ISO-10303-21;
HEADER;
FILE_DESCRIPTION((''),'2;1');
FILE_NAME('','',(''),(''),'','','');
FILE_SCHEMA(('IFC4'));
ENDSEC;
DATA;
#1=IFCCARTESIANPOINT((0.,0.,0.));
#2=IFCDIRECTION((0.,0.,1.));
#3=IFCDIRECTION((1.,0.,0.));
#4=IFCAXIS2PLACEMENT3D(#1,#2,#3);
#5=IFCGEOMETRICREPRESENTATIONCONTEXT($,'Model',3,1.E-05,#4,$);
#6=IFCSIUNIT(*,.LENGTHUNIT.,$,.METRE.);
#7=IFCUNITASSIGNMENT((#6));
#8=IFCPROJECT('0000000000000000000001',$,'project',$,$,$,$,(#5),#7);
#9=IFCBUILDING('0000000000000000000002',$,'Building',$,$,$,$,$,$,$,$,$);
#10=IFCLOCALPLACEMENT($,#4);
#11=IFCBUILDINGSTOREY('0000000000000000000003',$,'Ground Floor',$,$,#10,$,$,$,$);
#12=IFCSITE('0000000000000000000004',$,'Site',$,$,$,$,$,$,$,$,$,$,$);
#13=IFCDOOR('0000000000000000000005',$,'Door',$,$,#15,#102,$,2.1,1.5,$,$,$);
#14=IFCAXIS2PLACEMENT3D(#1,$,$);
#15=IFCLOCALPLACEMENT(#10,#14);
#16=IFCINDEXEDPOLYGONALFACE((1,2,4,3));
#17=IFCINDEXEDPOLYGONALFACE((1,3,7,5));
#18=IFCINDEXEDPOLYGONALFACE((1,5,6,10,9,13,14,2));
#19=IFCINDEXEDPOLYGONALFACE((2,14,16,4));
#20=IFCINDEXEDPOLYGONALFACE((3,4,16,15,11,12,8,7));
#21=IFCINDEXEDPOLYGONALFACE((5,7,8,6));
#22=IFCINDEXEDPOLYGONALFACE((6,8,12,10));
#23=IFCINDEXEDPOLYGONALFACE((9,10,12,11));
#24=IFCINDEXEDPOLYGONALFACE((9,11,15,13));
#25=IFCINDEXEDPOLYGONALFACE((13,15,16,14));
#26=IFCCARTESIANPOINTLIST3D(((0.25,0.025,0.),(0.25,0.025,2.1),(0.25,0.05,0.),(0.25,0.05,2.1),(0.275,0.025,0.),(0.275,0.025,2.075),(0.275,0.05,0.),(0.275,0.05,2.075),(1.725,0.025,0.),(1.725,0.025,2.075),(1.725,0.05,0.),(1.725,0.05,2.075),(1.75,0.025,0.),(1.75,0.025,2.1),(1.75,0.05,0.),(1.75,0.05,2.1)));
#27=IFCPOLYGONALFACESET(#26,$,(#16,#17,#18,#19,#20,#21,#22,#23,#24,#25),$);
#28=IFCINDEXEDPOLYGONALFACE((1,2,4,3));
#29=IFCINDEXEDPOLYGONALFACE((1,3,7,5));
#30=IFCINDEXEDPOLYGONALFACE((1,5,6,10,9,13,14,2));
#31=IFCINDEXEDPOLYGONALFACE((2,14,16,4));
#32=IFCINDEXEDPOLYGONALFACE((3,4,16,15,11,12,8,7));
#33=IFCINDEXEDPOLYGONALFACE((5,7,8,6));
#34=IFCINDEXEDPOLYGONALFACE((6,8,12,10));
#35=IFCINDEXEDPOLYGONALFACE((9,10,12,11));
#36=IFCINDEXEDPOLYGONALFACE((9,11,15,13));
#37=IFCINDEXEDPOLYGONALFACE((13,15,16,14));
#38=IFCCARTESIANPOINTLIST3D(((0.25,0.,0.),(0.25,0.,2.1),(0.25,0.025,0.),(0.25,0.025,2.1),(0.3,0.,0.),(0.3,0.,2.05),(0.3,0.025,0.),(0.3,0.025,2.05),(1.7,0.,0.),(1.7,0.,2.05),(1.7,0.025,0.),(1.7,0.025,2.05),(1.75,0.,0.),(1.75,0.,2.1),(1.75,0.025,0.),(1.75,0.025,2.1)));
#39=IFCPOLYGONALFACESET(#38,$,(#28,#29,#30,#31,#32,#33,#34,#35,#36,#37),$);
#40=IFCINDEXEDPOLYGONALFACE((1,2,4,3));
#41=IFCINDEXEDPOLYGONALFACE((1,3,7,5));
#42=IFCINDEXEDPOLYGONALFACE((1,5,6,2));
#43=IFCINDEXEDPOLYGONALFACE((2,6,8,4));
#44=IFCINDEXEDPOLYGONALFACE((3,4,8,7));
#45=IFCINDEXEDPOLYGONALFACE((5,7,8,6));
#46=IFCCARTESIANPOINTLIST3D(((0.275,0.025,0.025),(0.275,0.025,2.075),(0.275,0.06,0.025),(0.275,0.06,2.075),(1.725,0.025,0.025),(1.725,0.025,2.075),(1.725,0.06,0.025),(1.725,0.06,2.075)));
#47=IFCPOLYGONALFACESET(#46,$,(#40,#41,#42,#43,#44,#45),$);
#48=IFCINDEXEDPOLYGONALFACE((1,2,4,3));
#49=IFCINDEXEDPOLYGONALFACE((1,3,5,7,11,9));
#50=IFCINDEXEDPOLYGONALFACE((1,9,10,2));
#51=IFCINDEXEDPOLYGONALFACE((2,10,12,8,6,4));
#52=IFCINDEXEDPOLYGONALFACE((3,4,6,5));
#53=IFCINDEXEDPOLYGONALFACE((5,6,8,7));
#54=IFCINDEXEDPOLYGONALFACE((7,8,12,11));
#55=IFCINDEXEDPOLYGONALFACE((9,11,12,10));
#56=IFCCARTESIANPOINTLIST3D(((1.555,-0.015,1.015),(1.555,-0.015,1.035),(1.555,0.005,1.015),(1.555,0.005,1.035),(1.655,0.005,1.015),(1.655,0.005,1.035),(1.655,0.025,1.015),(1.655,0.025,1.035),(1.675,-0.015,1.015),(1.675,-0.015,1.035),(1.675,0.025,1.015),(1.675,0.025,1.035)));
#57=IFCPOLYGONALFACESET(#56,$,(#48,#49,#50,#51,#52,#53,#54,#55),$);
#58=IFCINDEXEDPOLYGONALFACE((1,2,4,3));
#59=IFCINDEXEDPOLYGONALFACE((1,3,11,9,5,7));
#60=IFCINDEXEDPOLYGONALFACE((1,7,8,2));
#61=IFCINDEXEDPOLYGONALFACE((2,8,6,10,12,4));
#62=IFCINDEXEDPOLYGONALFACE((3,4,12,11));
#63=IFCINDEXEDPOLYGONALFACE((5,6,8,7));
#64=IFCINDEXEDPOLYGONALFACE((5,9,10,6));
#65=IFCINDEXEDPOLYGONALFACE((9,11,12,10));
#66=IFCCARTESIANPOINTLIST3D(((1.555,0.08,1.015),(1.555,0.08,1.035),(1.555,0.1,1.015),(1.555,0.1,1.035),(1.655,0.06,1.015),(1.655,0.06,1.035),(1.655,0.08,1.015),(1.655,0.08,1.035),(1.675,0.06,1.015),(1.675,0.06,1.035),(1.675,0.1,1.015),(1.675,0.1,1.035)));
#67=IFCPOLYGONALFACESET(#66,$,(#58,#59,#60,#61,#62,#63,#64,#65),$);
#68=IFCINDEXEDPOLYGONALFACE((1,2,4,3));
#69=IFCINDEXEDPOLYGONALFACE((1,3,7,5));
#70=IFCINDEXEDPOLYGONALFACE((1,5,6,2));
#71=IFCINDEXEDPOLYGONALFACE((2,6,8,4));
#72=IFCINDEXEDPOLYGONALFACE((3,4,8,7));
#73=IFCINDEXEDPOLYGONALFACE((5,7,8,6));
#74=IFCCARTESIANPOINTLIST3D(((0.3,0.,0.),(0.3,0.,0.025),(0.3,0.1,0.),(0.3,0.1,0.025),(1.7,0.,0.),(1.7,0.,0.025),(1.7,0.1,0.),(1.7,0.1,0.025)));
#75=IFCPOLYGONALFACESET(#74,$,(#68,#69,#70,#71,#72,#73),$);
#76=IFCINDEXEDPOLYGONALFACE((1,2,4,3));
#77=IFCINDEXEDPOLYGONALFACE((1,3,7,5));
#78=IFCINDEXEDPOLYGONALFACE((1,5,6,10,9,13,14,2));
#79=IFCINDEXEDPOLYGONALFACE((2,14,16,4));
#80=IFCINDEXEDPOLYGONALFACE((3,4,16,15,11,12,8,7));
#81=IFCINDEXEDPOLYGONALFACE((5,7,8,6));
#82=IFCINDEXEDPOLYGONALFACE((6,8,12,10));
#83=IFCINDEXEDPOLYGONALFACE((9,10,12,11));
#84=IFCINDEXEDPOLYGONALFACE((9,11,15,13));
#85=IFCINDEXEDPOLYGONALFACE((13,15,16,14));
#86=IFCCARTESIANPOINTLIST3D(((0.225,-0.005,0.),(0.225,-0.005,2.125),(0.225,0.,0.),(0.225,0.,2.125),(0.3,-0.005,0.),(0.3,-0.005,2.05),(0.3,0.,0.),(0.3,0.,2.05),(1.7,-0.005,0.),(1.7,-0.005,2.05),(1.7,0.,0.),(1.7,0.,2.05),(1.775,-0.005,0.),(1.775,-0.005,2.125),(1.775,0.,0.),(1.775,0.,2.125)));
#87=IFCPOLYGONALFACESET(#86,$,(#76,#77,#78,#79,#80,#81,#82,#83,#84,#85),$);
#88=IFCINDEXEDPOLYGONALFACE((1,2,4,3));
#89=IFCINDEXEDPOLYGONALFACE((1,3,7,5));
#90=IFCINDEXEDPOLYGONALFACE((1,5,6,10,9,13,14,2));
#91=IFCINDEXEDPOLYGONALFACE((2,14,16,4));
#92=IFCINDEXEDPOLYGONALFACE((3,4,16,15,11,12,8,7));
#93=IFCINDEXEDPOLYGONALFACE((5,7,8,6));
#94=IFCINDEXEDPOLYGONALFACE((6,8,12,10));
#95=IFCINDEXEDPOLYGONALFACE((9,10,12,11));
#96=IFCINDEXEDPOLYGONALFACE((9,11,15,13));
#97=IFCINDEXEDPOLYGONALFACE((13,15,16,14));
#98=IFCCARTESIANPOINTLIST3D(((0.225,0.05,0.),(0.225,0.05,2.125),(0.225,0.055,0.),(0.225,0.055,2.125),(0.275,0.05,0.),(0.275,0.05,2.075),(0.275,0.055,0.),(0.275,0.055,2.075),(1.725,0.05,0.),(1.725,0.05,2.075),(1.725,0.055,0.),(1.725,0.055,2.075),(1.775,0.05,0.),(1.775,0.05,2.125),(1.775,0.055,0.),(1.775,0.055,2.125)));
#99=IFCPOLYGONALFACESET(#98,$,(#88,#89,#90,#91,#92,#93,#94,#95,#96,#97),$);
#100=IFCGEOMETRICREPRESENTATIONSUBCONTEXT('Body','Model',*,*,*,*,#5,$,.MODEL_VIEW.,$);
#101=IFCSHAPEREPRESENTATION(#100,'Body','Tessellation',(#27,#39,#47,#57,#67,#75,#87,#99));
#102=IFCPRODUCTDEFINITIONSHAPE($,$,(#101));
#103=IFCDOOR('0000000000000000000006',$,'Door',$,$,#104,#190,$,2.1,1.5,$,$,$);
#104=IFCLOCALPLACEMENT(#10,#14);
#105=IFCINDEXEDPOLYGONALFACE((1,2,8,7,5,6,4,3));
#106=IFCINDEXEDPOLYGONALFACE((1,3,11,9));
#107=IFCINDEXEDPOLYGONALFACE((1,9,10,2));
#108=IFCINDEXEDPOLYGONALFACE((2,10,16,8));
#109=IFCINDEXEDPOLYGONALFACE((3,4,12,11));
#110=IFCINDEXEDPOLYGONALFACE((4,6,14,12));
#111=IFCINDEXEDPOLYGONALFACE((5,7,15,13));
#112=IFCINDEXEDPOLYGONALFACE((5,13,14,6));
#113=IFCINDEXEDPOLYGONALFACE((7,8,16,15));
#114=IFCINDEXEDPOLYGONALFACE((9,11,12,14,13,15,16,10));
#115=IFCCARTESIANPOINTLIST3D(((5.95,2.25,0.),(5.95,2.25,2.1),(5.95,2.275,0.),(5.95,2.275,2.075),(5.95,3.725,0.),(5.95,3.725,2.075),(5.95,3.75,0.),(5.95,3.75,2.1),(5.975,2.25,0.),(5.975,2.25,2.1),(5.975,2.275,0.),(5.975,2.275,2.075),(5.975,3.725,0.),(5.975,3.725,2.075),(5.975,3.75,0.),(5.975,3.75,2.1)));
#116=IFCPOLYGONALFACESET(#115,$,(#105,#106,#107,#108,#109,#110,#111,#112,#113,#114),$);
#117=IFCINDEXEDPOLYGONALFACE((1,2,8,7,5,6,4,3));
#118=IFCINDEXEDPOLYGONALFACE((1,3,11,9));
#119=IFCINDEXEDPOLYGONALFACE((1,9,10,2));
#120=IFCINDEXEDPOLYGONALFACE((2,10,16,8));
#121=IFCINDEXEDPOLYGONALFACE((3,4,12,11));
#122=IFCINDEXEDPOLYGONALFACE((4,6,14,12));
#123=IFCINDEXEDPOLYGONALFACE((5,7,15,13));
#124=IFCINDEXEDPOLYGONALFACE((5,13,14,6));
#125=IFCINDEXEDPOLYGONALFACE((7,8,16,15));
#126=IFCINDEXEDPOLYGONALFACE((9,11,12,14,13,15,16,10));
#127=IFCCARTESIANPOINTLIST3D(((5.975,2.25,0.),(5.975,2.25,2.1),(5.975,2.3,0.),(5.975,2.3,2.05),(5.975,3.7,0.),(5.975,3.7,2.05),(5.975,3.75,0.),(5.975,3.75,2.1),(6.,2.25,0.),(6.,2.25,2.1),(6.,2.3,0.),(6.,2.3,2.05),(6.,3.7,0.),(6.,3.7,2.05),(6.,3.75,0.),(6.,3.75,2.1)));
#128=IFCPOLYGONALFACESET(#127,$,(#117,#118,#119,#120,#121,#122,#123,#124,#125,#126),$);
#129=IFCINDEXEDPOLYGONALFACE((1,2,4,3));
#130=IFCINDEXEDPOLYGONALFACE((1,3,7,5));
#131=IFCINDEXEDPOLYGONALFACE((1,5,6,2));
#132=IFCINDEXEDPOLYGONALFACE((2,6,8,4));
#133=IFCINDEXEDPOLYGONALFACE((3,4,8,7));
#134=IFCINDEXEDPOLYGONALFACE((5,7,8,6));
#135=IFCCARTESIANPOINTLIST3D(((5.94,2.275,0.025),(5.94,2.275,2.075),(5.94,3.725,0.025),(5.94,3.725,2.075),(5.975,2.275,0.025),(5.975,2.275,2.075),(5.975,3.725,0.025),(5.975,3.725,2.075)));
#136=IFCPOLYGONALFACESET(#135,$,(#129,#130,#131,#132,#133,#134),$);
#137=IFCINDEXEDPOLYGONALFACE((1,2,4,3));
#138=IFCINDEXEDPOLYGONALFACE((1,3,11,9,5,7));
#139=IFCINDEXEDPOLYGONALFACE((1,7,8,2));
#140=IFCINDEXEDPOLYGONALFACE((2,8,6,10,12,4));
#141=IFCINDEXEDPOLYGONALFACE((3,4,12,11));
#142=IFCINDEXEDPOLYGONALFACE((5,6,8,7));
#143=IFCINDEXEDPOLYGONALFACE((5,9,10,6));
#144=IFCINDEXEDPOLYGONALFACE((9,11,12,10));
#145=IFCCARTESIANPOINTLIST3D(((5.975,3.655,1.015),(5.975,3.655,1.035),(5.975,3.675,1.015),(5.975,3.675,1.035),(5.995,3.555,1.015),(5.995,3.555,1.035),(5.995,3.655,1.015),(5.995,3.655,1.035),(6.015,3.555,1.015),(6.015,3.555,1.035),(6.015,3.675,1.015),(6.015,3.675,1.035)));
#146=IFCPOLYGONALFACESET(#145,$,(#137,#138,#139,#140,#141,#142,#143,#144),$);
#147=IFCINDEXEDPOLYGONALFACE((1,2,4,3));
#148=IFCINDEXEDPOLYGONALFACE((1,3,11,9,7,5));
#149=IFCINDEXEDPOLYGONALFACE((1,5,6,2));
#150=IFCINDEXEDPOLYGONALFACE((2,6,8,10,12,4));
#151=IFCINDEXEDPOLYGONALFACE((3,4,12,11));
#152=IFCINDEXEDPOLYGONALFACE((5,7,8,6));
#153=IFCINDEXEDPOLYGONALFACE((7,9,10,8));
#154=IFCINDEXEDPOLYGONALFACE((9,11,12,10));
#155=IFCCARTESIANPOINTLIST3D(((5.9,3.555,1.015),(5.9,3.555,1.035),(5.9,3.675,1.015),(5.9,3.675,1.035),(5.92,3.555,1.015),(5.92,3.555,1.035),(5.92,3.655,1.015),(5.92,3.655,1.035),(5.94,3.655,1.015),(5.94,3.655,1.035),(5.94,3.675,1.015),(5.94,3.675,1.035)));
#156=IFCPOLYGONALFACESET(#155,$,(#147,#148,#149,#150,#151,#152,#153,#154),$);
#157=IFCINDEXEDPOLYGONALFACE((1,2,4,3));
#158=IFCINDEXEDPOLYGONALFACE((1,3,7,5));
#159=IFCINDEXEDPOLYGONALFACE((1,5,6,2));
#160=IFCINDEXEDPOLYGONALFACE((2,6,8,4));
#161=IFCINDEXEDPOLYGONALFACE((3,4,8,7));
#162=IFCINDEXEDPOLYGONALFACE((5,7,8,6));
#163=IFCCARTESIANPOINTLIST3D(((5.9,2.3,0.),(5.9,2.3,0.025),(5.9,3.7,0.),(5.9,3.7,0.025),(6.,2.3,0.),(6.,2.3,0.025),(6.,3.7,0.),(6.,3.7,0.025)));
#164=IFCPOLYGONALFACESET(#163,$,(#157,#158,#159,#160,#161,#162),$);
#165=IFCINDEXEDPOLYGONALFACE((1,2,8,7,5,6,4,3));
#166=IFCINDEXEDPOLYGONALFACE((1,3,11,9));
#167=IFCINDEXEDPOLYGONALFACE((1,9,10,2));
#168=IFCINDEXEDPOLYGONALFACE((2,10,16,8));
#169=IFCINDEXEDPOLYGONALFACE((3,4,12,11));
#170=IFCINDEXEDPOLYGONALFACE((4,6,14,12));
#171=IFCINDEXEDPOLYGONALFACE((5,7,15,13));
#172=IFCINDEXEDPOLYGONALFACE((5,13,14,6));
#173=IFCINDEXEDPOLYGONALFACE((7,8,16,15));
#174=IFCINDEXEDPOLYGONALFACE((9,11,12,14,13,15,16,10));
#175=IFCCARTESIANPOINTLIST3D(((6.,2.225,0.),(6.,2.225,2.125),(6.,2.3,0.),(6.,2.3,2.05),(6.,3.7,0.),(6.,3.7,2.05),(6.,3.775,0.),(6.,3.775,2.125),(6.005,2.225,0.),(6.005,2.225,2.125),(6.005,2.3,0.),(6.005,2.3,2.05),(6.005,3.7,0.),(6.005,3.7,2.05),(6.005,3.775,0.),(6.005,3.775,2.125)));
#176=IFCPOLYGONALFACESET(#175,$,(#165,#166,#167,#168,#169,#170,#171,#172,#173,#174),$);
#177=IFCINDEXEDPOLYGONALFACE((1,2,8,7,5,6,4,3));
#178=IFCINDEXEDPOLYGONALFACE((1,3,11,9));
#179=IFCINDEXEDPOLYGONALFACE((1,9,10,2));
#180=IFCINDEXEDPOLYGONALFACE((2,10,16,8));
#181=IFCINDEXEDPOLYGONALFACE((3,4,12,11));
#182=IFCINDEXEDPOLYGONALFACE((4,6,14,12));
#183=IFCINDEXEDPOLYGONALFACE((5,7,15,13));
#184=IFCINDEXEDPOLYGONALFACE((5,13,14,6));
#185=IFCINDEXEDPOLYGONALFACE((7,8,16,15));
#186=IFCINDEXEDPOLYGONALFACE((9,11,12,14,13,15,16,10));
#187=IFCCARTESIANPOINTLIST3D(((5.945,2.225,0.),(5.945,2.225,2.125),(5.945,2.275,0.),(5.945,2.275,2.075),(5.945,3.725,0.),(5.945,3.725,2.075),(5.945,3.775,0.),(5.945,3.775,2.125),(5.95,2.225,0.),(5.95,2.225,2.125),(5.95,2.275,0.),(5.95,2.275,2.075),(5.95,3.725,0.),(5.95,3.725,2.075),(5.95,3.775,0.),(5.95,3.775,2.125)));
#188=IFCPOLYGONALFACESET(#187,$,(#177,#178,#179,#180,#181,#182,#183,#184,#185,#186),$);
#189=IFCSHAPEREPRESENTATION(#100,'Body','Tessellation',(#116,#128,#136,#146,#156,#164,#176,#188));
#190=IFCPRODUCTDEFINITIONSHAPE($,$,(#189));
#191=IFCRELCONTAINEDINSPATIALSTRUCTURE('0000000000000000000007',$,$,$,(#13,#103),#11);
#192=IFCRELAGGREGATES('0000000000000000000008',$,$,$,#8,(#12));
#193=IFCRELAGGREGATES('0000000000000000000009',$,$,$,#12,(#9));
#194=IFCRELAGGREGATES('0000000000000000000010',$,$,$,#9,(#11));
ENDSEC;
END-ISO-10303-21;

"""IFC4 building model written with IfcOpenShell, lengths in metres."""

from ifc_helpers import new_model, si_unit, frame, origin_with_axes, place, context, subcontext, project, spatial, line, indexed_curve, outline, extrude, element, save


model = new_model("IFC4")

# Units and contexts
model_context = context("Model", 3, precision=1e-05, world=origin_with_axes())
body_context = subcontext(model_context, "Body", "Model", "MODEL_VIEW")
ifc_project = project(units=[si_unit("LENGTHUNIT", "METRE")], contexts=[model_context])

# Site, building, storey
site = spatial("IfcSite", under=ifc_project, Name="Site")
building = spatial("IfcBuilding", under=site, Name="Building")
storey_placement = place(None, origin_with_axes())
storey = spatial("IfcBuildingStorey", under=building, at=storey_placement, Name="Ground Floor")

# Doors
door_1_placement = place(storey_placement, frame((0.25, 0.0, 0.0), z_axis=(0.0, 0.0, 1.0), x_axis=(1.0, 0.0, 0.0)))
element("IfcDoor", 1, at=door_1_placement, inside=storey, Name="Door", OverallHeight=2.1, OverallWidth=1.5, context=body_context, shape_type="SweptSolid", body=[
    extrude(outline(indexed_curve([(0.0, 0.0), (0.0, 2.1), (1.5, 2.1), (1.5, 0.0), (1.475, 0.0), (1.475, 2.075), (0.025, 2.075), (0.025, 0.0)], segments=[line(1, 2, 3, 4, 5, 6, 7, 8, 1)])), frame((0.0, 0.025, 0.0), z_axis=(0.0, -1.0, 0.0), x_axis=(1.0, 0.0, 0.0)), (0.0, 0.0, -1.0), 0.025),
    extrude(outline(indexed_curve([(0.0, 0.0), (0.0, 2.1), (1.5, 2.1), (1.5, 0.0), (1.45, 0.0), (1.45, 2.05), (0.05, 2.05), (0.05, 0.0)], segments=[line(1, 2, 3, 4, 5, 6, 7, 8, 1)])), frame((0.0, 0.0, 0.0), z_axis=(0.0, -1.0, 0.0), x_axis=(1.0, 0.0, 0.0)), (0.0, 0.0, -1.0), 0.025),
    extrude(outline(indexed_curve([(0.0, 0.0), (1.45, 0.0), (1.45, 0.035), (0.0, 0.035)], segments=[line(1, 2, 3, 4, 1)])), frame((0.025, 0.025, 0.025), z_axis=(0.0, 0.0, 1.0), x_axis=(1.0, 0.0, 0.0)), (0.0, 0.0, 1.0), 2.05),
    extrude(outline(indexed_curve([(0.0, 0.0), (0.0, -0.04), (-0.12, -0.04), (-0.12, -0.02), (-0.02, -0.02), (-0.02, 0.0)], segments=[line(1, 2, 3, 4, 5, 6, 1)])), frame((1.425, 0.025, 1.015), z_axis=(0.0, 0.0, 1.0), x_axis=(1.0, 0.0, 0.0)), (0.0, 0.0, 1.0), 0.02),
    extrude(outline(indexed_curve([(0.0, 0.0), (0.0, 0.04), (-0.12, 0.04), (-0.12, 0.02), (-0.02, 0.02), (-0.02, 0.0)], segments=[line(1, 2, 3, 4, 5, 6, 1)])), frame((1.425, 0.06, 1.015), z_axis=(0.0, 0.0, 1.0), x_axis=(1.0, 0.0, 0.0)), (0.0, 0.0, 1.0), 0.02),
    extrude(outline(indexed_curve([(0.0, 0.0), (1.4, 0.0), (1.4, 0.1), (0.0, 0.1)], segments=[line(1, 2, 3, 4, 1)])), frame((0.05, 0.0, 0.0), z_axis=(0.0, 0.0, 1.0), x_axis=(1.0, 0.0, 0.0)), (0.0, 0.0, 1.0), 0.025),
    extrude(outline(indexed_curve([(0.0, 0.0), (0.0, 2.125), (1.55, 2.125), (1.55, 0.0), (1.475, 0.0), (1.475, 2.05), (0.075, 2.05), (0.075, 0.0)], segments=[line(1, 2, 3, 4, 5, 6, 7, 8, 1)])), frame((-0.025, -0.005, 0.0), z_axis=(0.0, -1.0, 0.0), x_axis=(1.0, 0.0, 0.0)), (0.0, 0.0, -1.0), 0.005),
    extrude(outline(indexed_curve([(0.0, 0.0), (0.0, 2.125), (1.55, 2.125), (1.55, 0.0), (1.5, 0.0), (1.5, 2.075), (0.05, 2.075), (0.05, 0.0)], segments=[line(1, 2, 3, 4, 5, 6, 7, 8, 1)])), frame((-0.025, 0.05, 0.0), z_axis=(0.0, -1.0, 0.0), x_axis=(1.0, 0.0, 0.0)), (0.0, 0.0, -1.0), 0.005),
])
door_2_placement = place(storey_placement, frame((6.0, 2.25, 0.0), z_axis=(0.0, 0.0, 1.0), x_axis=(0.0, 1.0, 0.0)))
element("IfcDoor", 2, at=door_2_placement, inside=storey, Name="Door", OverallHeight=2.1, OverallWidth=1.5, context=body_context, shape_type="SweptSolid", body=[
    extrude(outline(indexed_curve([(0.0, 0.0), (0.0, 2.1), (1.5, 2.1), (1.5, 0.0), (1.475, 0.0), (1.475, 2.075), (0.025, 2.075), (0.025, 0.0)], segments=[line(1, 2, 3, 4, 5, 6, 7, 8, 1)])), frame((0.0, 0.025, 0.0), z_axis=(0.0, -1.0, 0.0), x_axis=(1.0, 0.0, 0.0)), (0.0, 0.0, -1.0), 0.025),
    extrude(outline(indexed_curve([(0.0, 0.0), (0.0, 2.1), (1.5, 2.1), (1.5, 0.0), (1.45, 0.0), (1.45, 2.05), (0.05, 2.05), (0.05, 0.0)], segments=[line(1, 2, 3, 4, 5, 6, 7, 8, 1)])), frame((0.0, 0.0, 0.0), z_axis=(0.0, -1.0, 0.0), x_axis=(1.0, 0.0, 0.0)), (0.0, 0.0, -1.0), 0.025),
    extrude(outline(indexed_curve([(0.0, 0.0), (1.45, 0.0), (1.45, 0.035), (0.0, 0.035)], segments=[line(1, 2, 3, 4, 1)])), frame((0.025, 0.025, 0.025), z_axis=(0.0, 0.0, 1.0), x_axis=(1.0, 0.0, 0.0)), (0.0, 0.0, 1.0), 2.05),
    extrude(outline(indexed_curve([(0.0, 0.0), (0.0, -0.04), (-0.12, -0.04), (-0.12, -0.02), (-0.02, -0.02), (-0.02, 0.0)], segments=[line(1, 2, 3, 4, 5, 6, 1)])), frame((1.425, 0.025, 1.015), z_axis=(0.0, 0.0, 1.0), x_axis=(1.0, 0.0, 0.0)), (0.0, 0.0, 1.0), 0.02),
    extrude(outline(indexed_curve([(0.0, 0.0), (0.0, 0.04), (-0.12, 0.04), (-0.12, 0.02), (-0.02, 0.02), (-0.02, 0.0)], segments=[line(1, 2, 3, 4, 5, 6, 1)])), frame((1.425, 0.06, 1.015), z_axis=(0.0, 0.0, 1.0), x_axis=(1.0, 0.0, 0.0)), (0.0, 0.0, 1.0), 0.02),
    extrude(outline(indexed_curve([(0.0, 0.0), (1.4, 0.0), (1.4, 0.1), (0.0, 0.1)], segments=[line(1, 2, 3, 4, 1)])), frame((0.05, 0.0, 0.0), z_axis=(0.0, 0.0, 1.0), x_axis=(1.0, 0.0, 0.0)), (0.0, 0.0, 1.0), 0.025),
    extrude(outline(indexed_curve([(0.0, 0.0), (0.0, 2.125), (1.55, 2.125), (1.55, 0.0), (1.475, 0.0), (1.475, 2.05), (0.075, 2.05), (0.075, 0.0)], segments=[line(1, 2, 3, 4, 5, 6, 7, 8, 1)])), frame((-0.025, -0.005, 0.0), z_axis=(0.0, -1.0, 0.0), x_axis=(1.0, 0.0, 0.0)), (0.0, 0.0, -1.0), 0.005),
    extrude(outline(indexed_curve([(0.0, 0.0), (0.0, 2.125), (1.55, 2.125), (1.55, 0.0), (1.5, 0.0), (1.5, 2.075), (0.05, 2.075), (0.05, 0.0)], segments=[line(1, 2, 3, 4, 5, 6, 7, 8, 1)])), frame((-0.025, 0.05, 0.0), z_axis=(0.0, -1.0, 0.0), x_axis=(1.0, 0.0, 0.0)), (0.0, 0.0, -1.0), 0.005),
])

save(model, "model.ifc")
